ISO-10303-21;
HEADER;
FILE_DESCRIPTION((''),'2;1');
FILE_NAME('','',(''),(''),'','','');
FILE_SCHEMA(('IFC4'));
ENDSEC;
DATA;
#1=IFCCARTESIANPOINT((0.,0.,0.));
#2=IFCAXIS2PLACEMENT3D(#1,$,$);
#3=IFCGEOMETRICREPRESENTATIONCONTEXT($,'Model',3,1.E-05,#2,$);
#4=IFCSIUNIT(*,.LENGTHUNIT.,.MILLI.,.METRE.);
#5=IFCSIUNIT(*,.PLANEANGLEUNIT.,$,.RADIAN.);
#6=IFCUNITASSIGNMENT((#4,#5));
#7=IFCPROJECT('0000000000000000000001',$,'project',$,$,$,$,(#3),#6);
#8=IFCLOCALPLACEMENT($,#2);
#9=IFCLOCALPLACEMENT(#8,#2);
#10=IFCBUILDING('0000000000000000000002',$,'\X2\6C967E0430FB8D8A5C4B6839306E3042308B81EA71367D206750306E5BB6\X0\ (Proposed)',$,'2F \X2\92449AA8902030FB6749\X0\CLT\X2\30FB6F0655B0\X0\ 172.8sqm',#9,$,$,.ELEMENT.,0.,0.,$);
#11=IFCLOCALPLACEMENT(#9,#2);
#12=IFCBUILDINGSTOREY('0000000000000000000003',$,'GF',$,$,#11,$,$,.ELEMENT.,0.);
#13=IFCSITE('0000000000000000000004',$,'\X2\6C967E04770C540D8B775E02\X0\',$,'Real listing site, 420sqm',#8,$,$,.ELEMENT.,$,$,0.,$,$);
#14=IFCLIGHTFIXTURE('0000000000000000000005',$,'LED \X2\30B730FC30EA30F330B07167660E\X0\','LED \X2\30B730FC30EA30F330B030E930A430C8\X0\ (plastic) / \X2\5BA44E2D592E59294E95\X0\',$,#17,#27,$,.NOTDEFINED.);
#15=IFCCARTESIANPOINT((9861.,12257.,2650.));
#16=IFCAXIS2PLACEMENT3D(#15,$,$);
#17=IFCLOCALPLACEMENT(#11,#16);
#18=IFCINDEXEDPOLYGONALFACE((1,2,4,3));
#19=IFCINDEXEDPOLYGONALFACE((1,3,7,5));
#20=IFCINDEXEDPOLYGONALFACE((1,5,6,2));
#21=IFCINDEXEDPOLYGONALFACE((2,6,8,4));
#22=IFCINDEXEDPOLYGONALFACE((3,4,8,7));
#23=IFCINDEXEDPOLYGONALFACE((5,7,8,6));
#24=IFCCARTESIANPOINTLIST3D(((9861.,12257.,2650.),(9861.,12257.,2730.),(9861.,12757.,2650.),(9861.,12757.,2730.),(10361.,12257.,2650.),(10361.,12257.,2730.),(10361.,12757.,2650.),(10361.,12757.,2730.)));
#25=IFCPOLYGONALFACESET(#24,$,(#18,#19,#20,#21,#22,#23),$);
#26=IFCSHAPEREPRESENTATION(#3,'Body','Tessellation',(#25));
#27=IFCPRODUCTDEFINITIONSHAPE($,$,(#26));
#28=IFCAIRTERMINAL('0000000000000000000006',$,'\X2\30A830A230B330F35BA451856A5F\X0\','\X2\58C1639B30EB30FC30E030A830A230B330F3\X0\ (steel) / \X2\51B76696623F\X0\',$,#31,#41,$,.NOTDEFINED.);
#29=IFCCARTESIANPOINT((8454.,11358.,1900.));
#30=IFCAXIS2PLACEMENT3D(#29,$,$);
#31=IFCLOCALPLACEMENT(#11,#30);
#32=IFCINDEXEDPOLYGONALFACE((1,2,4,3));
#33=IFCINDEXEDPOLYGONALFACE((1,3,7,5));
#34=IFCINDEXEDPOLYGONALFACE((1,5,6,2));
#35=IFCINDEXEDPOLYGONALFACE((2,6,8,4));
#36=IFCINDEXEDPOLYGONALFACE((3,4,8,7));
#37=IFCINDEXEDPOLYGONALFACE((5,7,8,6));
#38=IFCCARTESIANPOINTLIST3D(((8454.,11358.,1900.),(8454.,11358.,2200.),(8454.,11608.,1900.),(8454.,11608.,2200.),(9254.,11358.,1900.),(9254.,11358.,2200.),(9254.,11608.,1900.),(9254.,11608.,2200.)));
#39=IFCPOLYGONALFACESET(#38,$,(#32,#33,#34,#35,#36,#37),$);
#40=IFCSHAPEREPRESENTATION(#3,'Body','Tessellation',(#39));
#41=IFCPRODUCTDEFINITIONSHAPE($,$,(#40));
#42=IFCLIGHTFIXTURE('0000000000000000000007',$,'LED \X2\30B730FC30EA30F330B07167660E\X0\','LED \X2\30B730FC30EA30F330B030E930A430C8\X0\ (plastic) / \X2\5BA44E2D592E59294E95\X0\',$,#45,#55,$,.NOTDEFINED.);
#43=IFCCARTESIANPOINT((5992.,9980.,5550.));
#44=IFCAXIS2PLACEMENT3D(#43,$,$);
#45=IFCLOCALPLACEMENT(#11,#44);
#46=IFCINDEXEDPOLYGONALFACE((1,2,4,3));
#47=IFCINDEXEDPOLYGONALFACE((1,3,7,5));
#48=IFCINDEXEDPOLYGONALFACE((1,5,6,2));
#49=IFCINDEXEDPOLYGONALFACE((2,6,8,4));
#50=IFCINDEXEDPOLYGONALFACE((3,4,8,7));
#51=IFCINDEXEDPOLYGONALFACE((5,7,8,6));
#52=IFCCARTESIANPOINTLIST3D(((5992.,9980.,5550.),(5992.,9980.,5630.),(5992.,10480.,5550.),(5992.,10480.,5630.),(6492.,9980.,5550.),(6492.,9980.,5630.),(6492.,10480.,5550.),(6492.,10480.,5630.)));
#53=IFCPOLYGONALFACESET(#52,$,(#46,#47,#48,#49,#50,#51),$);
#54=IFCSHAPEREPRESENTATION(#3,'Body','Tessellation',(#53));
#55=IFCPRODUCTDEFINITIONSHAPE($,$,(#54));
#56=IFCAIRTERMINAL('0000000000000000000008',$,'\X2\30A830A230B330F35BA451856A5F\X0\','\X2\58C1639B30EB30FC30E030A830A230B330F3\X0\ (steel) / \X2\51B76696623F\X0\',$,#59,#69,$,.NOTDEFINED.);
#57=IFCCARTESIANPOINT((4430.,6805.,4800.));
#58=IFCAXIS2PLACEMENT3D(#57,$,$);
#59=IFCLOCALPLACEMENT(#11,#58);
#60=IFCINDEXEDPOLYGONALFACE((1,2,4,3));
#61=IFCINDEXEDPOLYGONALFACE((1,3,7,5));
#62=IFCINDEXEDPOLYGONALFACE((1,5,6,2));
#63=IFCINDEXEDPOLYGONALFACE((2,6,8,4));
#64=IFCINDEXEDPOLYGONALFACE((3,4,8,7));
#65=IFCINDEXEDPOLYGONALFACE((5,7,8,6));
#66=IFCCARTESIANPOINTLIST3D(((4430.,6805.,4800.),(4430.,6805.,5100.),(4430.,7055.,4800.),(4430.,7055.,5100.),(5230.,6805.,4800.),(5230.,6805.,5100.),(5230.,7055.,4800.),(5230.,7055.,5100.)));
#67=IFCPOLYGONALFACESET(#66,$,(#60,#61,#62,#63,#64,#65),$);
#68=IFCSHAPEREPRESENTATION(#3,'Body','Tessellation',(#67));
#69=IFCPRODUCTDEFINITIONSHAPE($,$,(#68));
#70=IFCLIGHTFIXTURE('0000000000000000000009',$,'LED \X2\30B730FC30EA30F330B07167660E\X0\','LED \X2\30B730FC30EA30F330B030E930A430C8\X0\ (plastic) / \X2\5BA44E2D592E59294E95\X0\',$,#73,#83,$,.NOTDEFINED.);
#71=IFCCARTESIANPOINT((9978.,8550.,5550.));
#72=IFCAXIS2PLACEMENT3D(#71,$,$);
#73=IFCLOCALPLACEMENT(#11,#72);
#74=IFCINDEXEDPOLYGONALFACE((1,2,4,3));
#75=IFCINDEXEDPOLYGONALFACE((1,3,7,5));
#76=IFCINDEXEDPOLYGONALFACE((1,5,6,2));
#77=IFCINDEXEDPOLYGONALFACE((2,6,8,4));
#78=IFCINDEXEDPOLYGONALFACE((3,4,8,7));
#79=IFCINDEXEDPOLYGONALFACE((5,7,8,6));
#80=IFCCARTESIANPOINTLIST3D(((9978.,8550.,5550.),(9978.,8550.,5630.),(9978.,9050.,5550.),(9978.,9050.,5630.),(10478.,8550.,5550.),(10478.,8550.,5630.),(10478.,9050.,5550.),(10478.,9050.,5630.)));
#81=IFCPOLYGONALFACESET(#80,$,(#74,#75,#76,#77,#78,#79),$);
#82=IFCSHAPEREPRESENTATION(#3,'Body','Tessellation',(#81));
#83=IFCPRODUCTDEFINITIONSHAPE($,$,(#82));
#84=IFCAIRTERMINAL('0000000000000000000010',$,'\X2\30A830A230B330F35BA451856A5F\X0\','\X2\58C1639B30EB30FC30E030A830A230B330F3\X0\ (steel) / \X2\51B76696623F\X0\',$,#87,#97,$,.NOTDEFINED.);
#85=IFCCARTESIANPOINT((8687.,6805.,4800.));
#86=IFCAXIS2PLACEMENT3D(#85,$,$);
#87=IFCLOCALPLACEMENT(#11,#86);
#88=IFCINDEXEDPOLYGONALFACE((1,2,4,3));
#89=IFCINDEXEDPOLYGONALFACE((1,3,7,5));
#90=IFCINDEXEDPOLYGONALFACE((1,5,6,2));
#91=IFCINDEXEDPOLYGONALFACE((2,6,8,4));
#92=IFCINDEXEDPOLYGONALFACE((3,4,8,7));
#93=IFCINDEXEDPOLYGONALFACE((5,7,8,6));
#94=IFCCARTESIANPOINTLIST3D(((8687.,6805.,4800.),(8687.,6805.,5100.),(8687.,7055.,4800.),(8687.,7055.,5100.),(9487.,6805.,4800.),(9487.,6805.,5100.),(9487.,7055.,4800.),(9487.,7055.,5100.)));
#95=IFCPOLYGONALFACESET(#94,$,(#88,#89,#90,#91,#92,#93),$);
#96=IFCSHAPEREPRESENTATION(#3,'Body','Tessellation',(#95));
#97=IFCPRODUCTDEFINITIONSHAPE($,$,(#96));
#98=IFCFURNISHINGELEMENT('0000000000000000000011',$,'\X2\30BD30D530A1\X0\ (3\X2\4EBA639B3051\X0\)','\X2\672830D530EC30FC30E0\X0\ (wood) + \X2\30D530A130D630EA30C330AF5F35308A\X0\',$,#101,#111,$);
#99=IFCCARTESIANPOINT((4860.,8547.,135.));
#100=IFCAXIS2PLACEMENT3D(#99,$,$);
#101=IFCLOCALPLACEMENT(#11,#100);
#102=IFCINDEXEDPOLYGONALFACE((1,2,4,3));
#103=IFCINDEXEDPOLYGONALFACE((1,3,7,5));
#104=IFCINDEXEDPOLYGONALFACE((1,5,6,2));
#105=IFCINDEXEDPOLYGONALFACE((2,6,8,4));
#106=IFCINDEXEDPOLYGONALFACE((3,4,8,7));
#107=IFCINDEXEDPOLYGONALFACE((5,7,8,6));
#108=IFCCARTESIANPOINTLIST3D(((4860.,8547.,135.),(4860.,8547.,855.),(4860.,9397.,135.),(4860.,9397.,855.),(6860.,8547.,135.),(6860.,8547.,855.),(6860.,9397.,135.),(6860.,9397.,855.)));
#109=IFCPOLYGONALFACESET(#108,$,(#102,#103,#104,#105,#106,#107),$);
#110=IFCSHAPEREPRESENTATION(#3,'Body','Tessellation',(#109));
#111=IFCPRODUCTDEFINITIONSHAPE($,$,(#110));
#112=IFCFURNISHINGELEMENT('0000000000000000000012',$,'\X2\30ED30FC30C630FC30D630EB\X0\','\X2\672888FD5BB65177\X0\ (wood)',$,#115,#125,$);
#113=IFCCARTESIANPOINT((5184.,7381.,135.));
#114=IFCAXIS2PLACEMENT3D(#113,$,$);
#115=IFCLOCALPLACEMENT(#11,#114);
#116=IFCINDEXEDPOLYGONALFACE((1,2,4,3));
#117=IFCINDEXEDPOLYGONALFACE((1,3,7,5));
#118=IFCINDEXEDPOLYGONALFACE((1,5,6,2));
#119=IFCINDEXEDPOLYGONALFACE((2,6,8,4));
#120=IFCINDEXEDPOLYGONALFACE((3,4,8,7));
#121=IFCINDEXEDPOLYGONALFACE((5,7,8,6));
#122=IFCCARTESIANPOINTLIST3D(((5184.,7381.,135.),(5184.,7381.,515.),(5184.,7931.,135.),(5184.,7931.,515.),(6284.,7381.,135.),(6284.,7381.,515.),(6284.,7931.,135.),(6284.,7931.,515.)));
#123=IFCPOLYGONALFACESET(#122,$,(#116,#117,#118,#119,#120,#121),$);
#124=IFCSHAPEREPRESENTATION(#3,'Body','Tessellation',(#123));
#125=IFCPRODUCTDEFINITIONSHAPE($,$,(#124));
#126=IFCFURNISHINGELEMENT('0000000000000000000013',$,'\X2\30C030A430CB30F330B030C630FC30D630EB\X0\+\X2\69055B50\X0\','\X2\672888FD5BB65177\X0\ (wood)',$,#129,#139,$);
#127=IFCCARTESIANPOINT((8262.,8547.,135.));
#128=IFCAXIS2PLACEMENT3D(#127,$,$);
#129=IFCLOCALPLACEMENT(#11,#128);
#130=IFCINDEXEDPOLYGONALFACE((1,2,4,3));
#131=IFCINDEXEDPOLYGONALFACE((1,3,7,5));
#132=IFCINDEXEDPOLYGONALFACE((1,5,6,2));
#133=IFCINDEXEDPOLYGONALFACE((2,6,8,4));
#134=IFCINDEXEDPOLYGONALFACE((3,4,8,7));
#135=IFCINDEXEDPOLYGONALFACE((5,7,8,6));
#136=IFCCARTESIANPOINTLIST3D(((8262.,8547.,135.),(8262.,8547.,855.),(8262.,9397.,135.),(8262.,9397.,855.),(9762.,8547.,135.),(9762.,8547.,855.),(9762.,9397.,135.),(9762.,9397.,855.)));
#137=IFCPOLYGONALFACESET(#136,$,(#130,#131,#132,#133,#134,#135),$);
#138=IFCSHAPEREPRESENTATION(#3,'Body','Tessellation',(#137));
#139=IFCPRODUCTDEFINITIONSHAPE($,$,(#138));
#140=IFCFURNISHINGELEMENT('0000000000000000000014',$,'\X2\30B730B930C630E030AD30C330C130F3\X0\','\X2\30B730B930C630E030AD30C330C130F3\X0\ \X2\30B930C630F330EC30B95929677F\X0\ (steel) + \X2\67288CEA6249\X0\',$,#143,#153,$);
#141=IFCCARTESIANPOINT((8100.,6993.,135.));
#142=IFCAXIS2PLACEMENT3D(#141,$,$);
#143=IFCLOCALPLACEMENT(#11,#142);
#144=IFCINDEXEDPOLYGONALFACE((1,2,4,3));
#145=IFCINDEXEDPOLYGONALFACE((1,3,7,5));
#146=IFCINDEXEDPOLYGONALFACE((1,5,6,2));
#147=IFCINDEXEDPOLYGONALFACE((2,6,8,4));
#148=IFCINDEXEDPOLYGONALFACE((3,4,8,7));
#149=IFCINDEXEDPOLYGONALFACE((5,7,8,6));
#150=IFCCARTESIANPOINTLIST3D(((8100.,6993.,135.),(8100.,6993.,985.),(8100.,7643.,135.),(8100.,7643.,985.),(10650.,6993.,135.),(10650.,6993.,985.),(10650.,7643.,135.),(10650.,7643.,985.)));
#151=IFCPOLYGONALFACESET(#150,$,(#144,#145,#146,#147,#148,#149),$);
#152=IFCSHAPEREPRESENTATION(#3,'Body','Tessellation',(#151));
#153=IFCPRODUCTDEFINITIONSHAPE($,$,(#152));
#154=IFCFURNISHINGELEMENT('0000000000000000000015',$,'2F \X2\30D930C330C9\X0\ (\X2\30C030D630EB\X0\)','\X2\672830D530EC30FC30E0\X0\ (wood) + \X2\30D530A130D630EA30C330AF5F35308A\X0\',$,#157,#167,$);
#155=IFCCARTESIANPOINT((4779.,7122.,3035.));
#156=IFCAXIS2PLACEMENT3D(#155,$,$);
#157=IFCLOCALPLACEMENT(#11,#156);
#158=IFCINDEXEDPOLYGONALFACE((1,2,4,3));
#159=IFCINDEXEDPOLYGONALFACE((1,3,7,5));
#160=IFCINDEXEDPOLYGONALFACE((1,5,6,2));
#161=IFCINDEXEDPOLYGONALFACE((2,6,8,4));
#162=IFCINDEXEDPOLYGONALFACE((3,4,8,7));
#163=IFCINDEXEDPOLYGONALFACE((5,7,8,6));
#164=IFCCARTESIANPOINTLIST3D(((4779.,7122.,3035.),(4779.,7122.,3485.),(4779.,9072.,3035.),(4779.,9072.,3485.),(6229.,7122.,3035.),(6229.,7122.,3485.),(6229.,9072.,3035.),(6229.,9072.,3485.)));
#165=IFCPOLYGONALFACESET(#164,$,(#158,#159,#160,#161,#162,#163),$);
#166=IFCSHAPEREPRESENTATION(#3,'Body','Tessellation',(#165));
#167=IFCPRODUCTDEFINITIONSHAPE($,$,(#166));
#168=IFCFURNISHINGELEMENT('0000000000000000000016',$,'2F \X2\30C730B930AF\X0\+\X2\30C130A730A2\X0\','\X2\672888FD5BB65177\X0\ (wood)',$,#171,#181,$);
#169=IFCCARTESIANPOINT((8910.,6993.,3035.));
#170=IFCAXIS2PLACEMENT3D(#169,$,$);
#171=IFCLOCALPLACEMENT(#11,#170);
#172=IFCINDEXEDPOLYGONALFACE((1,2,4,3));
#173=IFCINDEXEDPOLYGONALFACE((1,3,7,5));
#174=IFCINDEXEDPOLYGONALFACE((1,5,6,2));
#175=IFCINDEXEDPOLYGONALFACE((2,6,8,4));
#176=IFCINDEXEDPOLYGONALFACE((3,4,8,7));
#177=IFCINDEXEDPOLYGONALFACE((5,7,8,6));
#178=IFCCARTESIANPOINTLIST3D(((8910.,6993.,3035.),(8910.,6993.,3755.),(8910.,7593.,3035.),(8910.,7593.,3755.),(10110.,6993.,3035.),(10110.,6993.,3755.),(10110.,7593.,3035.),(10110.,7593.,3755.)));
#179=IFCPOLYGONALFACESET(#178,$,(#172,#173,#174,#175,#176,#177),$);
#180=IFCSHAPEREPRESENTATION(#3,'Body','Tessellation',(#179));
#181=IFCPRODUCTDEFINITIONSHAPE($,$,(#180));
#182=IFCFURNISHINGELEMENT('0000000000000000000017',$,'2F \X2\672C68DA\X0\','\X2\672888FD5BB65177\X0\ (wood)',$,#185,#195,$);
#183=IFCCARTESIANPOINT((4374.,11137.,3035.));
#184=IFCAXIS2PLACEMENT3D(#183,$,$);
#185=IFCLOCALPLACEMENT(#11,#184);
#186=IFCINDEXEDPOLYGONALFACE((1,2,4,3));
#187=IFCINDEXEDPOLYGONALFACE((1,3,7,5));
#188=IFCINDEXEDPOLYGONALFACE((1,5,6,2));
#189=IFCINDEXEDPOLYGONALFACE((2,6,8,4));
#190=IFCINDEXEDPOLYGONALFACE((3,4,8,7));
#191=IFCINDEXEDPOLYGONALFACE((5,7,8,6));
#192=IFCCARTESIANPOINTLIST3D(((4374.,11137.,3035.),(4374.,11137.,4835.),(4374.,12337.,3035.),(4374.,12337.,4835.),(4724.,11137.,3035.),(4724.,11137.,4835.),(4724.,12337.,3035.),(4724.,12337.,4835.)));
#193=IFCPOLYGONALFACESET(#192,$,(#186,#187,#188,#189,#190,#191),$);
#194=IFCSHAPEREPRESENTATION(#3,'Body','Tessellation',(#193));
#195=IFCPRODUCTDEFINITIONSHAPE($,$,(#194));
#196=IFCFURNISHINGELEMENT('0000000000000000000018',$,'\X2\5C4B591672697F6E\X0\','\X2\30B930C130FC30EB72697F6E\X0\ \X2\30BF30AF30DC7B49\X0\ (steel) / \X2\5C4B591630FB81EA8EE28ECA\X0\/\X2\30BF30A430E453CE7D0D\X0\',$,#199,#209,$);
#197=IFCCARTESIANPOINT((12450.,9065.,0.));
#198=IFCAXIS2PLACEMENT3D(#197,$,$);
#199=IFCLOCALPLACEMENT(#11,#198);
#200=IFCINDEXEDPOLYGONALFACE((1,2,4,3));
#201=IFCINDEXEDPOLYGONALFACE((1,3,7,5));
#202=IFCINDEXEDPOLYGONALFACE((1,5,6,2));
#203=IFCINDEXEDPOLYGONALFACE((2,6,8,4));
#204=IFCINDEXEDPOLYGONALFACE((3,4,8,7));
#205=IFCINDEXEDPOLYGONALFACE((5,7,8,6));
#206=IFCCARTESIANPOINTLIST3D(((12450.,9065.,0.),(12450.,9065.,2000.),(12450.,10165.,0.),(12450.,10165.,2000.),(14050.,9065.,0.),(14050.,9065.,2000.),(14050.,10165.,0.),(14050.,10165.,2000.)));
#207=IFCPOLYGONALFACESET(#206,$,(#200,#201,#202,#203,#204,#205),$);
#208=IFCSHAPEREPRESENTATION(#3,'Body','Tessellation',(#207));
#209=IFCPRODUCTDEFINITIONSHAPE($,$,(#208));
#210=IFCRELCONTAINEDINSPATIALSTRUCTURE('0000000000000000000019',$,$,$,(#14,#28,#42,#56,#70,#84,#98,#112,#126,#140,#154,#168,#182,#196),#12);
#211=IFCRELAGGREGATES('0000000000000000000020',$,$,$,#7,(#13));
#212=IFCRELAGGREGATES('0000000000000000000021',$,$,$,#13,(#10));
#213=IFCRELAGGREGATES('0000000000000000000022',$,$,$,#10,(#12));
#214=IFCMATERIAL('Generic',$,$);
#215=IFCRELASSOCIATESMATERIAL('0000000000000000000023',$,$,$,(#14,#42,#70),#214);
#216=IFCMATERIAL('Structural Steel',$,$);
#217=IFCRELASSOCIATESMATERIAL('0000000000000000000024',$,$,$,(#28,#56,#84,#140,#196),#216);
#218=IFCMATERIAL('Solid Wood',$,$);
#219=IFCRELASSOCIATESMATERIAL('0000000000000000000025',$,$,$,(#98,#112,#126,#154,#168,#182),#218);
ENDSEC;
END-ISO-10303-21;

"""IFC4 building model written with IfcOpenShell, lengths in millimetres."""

from ifc_helpers import new_model, si_unit, frame, frame_2d, origin, place, context, project, spatial, rectangle, extrude, material, element, save


model = new_model("IFC4")

# Units and contexts
model_context = context("Model", 3, precision=1e-05, world=origin())
ifc_project = project(units=[si_unit("LENGTHUNIT", "METRE", prefix="MILLI"), si_unit("PLANEANGLEUNIT", "RADIAN")], contexts=[model_context])

# Site, building, storey
site_placement = place(None, origin())
site = spatial("IfcSite", under=ifc_project, at=site_placement, Name="沖縄県名護市", ObjectType="Real listing site, 420sqm", CompositionType="ELEMENT", RefElevation=0.0)
building_placement = place(site_placement, origin())
building = spatial("IfcBuilding", under=site, at=building_placement, Name="沖縄・越屋根のある自然素材の家 (Proposed)", ObjectType="2F 鉄骨造・杉CLT・漆喰 172.8sqm", CompositionType="ELEMENT", ElevationOfRefHeight=0.0, ElevationOfTerrain=0.0)
storey_placement = place(building_placement, origin())
storey = spatial("IfcBuildingStorey", under=building, at=storey_placement, Name="GF", CompositionType="ELEMENT", Elevation=0.0)

# Shared definitions
ifc_material_1 = material(Name="Solid Wood")

# Shared definitions
ifc_material_2 = material(Name="Structural Steel")

# Shared definitions
ifc_material_3 = material(Name="Generic")

# Light fixture
light_fixture_1_placement = place(storey_placement, frame((9861.0, 12257.0, 2650.0)))
element("IfcLightFixture", 1, at=light_fixture_1_placement, inside=storey, material=ifc_material_3, Name="LED シーリング照明", Description="LED シーリングライト (plastic) / 室中央天井", PredefinedType="NOTDEFINED", context=model_context, shape_type="SweptSolid", body=[
    extrude(rectangle(XDim=500.0, YDim=500.0, at=frame_2d((250.0, 250.0))), frame((9861.0, 12257.0, 2650.0)), (0.0, 0.0, 1.0), 80.0),
])

# Air terminal
air_terminal_1_placement = place(storey_placement, frame((8454.0, 11358.0, 1900.0)))
element("IfcAirTerminal", 2, at=air_terminal_1_placement, inside=storey, material=ifc_material_2, Name="エアコン室内機", Description="壁掛ルームエアコン (steel) / 冷暖房", PredefinedType="NOTDEFINED", context=model_context, shape_type="SweptSolid", body=[
    extrude(rectangle(XDim=800.0, YDim=250.0, at=frame_2d((400.0, 125.0))), frame((8454.0, 11358.0, 1900.0)), (0.0, 0.0, 1.0), 300.0),
])

# Light fixture
light_fixture_2_placement = place(storey_placement, frame((5992.0, 9980.0, 5550.0)))
element("IfcLightFixture", 3, at=light_fixture_2_placement, inside=storey, material=ifc_material_3, Name="LED シーリング照明", Description="LED シーリングライト (plastic) / 室中央天井", PredefinedType="NOTDEFINED", context=model_context, shape_type="SweptSolid", body=[
    extrude(rectangle(XDim=500.0, YDim=500.0, at=frame_2d((250.0, 250.0))), frame((5992.0, 9980.0, 5550.0)), (0.0, 0.0, 1.0), 80.0),
])

# Air terminal
air_terminal_2_placement = place(storey_placement, frame((4430.0, 6805.0, 4800.0)))
element("IfcAirTerminal", 4, at=air_terminal_2_placement, inside=storey, material=ifc_material_2, Name="エアコン室内機", Description="壁掛ルームエアコン (steel) / 冷暖房", PredefinedType="NOTDEFINED", context=model_context, shape_type="SweptSolid", body=[
    extrude(rectangle(XDim=800.0, YDim=250.0, at=frame_2d((400.0, 125.0))), frame((4430.0, 6805.0, 4800.0)), (0.0, 0.0, 1.0), 300.0),
])

# Light fixture
light_fixture_3_placement = place(storey_placement, frame((9978.0, 8550.0, 5550.0)))
element("IfcLightFixture", 5, at=light_fixture_3_placement, inside=storey, material=ifc_material_3, Name="LED シーリング照明", Description="LED シーリングライト (plastic) / 室中央天井", PredefinedType="NOTDEFINED", context=model_context, shape_type="SweptSolid", body=[
    extrude(rectangle(XDim=500.0, YDim=500.0, at=frame_2d((250.0, 250.0))), frame((9978.0, 8550.0, 5550.0)), (0.0, 0.0, 1.0), 80.0),
])

# Air terminal
air_terminal_3_placement = place(storey_placement, frame((8687.0, 6805.0, 4800.0)))
element("IfcAirTerminal", 6, at=air_terminal_3_placement, inside=storey, material=ifc_material_2, Name="エアコン室内機", Description="壁掛ルームエアコン (steel) / 冷暖房", PredefinedType="NOTDEFINED", context=model_context, shape_type="SweptSolid", body=[
    extrude(rectangle(XDim=800.0, YDim=250.0, at=frame_2d((400.0, 125.0))), frame((8687.0, 6805.0, 4800.0)), (0.0, 0.0, 1.0), 300.0),
])

# Furnishing elements
furnishing_1_placement = place(storey_placement, frame((4860.0, 8547.0, 135.0)))
element("IfcFurnishingElement", 7, at=furnishing_1_placement, inside=storey, material=ifc_material_1, Name="ソファ (3人掛け)", Description="木フレーム (wood) + ファブリック張り", context=model_context, shape_type="SweptSolid", body=[
    extrude(rectangle(XDim=2000.0, YDim=850.0, at=frame_2d((1000.0, 425.0))), frame((4860.0, 8547.0, 135.0)), (0.0, 0.0, 1.0), 720.0),
])
furnishing_2_placement = place(storey_placement, frame((5184.0, 7381.0, 135.0)))
element("IfcFurnishingElement", 8, at=furnishing_2_placement, inside=storey, material=ifc_material_1, Name="ローテーブル", Description="木製家具 (wood)", context=model_context, shape_type="SweptSolid", body=[
    extrude(rectangle(XDim=1100.0, YDim=550.0, at=frame_2d((550.0, 275.0))), frame((5184.0, 7381.0, 135.0)), (0.0, 0.0, 1.0), 380.0),
])
furnishing_3_placement = place(storey_placement, frame((8262.0, 8547.0, 135.0)))
element("IfcFurnishingElement", 9, at=furnishing_3_placement, inside=storey, material=ifc_material_1, Name="ダイニングテーブル+椅子", Description="木製家具 (wood)", context=model_context, shape_type="SweptSolid", body=[
    extrude(rectangle(XDim=1500.0, YDim=850.0, at=frame_2d((750.0, 425.0))), frame((8262.0, 8547.0, 135.0)), (0.0, 0.0, 1.0), 720.0),
])
furnishing_4_placement = place(storey_placement, frame((8100.0, 6993.0, 135.0)))
element("IfcFurnishingElement", 10, at=furnishing_4_placement, inside=storey, material=ifc_material_2, Name="システムキッチン", Description="システムキッチン ステンレス天板 (steel) + 木質扉", context=model_context, shape_type="SweptSolid", body=[
    extrude(rectangle(XDim=2550.0, YDim=650.0, at=frame_2d((1275.0, 325.0))), frame((8100.0, 6993.0, 135.0)), (0.0, 0.0, 1.0), 850.0),
])
furnishing_5_placement = place(storey_placement, frame((4779.0, 7122.0, 3035.0)))
element("IfcFurnishingElement", 11, at=furnishing_5_placement, inside=storey, material=ifc_material_1, Name="2F ベッド (ダブル)", Description="木フレーム (wood) + ファブリック張り", context=model_context, shape_type="SweptSolid", body=[
    extrude(rectangle(XDim=1450.0, YDim=1950.0, at=frame_2d((725.0, 975.0))), frame((4779.0, 7122.0, 3035.0)), (0.0, 0.0, 1.0), 450.0),
])
furnishing_6_placement = place(storey_placement, frame((8910.0, 6993.0, 3035.0)))
element("IfcFurnishingElement", 12, at=furnishing_6_placement, inside=storey, material=ifc_material_1, Name="2F デスク+チェア", Description="木製家具 (wood)", context=model_context, shape_type="SweptSolid", body=[
    extrude(rectangle(XDim=1200.0, YDim=600.0, at=frame_2d((600.0, 300.0))), frame((8910.0, 6993.0, 3035.0)), (0.0, 0.0, 1.0), 720.0),
])
furnishing_7_placement = place(storey_placement, frame((4374.0, 11137.0, 3035.0)))
element("IfcFurnishingElement", 13, at=furnishing_7_placement, inside=storey, material=ifc_material_1, Name="2F 本棚", Description="木製家具 (wood)", context=model_context, shape_type="SweptSolid", body=[
    extrude(rectangle(XDim=350.0, YDim=1200.0, at=frame_2d((175.0, 600.0))), frame((4374.0, 11137.0, 3035.0)), (0.0, 0.0, 1.0), 1800.0),
])
furnishing_8_placement = place(storey_placement, frame((12450.0, 9065.0, 0.0)))
element("IfcFurnishingElement", 14, at=furnishing_8_placement, inside=storey, material=ifc_material_2, Name="屋外物置", Description="スチール物置 タクボ等 (steel) / 屋外・自転車/タイヤ収納", context=model_context, shape_type="SweptSolid", body=[
    extrude(rectangle(XDim=1600.0, YDim=1100.0, at=frame_2d((800.0, 550.0))), frame((12450.0, 9065.0, 0.0)), (0.0, 0.0, 1.0), 2000.0),
])

save(model, "model.ifc")
